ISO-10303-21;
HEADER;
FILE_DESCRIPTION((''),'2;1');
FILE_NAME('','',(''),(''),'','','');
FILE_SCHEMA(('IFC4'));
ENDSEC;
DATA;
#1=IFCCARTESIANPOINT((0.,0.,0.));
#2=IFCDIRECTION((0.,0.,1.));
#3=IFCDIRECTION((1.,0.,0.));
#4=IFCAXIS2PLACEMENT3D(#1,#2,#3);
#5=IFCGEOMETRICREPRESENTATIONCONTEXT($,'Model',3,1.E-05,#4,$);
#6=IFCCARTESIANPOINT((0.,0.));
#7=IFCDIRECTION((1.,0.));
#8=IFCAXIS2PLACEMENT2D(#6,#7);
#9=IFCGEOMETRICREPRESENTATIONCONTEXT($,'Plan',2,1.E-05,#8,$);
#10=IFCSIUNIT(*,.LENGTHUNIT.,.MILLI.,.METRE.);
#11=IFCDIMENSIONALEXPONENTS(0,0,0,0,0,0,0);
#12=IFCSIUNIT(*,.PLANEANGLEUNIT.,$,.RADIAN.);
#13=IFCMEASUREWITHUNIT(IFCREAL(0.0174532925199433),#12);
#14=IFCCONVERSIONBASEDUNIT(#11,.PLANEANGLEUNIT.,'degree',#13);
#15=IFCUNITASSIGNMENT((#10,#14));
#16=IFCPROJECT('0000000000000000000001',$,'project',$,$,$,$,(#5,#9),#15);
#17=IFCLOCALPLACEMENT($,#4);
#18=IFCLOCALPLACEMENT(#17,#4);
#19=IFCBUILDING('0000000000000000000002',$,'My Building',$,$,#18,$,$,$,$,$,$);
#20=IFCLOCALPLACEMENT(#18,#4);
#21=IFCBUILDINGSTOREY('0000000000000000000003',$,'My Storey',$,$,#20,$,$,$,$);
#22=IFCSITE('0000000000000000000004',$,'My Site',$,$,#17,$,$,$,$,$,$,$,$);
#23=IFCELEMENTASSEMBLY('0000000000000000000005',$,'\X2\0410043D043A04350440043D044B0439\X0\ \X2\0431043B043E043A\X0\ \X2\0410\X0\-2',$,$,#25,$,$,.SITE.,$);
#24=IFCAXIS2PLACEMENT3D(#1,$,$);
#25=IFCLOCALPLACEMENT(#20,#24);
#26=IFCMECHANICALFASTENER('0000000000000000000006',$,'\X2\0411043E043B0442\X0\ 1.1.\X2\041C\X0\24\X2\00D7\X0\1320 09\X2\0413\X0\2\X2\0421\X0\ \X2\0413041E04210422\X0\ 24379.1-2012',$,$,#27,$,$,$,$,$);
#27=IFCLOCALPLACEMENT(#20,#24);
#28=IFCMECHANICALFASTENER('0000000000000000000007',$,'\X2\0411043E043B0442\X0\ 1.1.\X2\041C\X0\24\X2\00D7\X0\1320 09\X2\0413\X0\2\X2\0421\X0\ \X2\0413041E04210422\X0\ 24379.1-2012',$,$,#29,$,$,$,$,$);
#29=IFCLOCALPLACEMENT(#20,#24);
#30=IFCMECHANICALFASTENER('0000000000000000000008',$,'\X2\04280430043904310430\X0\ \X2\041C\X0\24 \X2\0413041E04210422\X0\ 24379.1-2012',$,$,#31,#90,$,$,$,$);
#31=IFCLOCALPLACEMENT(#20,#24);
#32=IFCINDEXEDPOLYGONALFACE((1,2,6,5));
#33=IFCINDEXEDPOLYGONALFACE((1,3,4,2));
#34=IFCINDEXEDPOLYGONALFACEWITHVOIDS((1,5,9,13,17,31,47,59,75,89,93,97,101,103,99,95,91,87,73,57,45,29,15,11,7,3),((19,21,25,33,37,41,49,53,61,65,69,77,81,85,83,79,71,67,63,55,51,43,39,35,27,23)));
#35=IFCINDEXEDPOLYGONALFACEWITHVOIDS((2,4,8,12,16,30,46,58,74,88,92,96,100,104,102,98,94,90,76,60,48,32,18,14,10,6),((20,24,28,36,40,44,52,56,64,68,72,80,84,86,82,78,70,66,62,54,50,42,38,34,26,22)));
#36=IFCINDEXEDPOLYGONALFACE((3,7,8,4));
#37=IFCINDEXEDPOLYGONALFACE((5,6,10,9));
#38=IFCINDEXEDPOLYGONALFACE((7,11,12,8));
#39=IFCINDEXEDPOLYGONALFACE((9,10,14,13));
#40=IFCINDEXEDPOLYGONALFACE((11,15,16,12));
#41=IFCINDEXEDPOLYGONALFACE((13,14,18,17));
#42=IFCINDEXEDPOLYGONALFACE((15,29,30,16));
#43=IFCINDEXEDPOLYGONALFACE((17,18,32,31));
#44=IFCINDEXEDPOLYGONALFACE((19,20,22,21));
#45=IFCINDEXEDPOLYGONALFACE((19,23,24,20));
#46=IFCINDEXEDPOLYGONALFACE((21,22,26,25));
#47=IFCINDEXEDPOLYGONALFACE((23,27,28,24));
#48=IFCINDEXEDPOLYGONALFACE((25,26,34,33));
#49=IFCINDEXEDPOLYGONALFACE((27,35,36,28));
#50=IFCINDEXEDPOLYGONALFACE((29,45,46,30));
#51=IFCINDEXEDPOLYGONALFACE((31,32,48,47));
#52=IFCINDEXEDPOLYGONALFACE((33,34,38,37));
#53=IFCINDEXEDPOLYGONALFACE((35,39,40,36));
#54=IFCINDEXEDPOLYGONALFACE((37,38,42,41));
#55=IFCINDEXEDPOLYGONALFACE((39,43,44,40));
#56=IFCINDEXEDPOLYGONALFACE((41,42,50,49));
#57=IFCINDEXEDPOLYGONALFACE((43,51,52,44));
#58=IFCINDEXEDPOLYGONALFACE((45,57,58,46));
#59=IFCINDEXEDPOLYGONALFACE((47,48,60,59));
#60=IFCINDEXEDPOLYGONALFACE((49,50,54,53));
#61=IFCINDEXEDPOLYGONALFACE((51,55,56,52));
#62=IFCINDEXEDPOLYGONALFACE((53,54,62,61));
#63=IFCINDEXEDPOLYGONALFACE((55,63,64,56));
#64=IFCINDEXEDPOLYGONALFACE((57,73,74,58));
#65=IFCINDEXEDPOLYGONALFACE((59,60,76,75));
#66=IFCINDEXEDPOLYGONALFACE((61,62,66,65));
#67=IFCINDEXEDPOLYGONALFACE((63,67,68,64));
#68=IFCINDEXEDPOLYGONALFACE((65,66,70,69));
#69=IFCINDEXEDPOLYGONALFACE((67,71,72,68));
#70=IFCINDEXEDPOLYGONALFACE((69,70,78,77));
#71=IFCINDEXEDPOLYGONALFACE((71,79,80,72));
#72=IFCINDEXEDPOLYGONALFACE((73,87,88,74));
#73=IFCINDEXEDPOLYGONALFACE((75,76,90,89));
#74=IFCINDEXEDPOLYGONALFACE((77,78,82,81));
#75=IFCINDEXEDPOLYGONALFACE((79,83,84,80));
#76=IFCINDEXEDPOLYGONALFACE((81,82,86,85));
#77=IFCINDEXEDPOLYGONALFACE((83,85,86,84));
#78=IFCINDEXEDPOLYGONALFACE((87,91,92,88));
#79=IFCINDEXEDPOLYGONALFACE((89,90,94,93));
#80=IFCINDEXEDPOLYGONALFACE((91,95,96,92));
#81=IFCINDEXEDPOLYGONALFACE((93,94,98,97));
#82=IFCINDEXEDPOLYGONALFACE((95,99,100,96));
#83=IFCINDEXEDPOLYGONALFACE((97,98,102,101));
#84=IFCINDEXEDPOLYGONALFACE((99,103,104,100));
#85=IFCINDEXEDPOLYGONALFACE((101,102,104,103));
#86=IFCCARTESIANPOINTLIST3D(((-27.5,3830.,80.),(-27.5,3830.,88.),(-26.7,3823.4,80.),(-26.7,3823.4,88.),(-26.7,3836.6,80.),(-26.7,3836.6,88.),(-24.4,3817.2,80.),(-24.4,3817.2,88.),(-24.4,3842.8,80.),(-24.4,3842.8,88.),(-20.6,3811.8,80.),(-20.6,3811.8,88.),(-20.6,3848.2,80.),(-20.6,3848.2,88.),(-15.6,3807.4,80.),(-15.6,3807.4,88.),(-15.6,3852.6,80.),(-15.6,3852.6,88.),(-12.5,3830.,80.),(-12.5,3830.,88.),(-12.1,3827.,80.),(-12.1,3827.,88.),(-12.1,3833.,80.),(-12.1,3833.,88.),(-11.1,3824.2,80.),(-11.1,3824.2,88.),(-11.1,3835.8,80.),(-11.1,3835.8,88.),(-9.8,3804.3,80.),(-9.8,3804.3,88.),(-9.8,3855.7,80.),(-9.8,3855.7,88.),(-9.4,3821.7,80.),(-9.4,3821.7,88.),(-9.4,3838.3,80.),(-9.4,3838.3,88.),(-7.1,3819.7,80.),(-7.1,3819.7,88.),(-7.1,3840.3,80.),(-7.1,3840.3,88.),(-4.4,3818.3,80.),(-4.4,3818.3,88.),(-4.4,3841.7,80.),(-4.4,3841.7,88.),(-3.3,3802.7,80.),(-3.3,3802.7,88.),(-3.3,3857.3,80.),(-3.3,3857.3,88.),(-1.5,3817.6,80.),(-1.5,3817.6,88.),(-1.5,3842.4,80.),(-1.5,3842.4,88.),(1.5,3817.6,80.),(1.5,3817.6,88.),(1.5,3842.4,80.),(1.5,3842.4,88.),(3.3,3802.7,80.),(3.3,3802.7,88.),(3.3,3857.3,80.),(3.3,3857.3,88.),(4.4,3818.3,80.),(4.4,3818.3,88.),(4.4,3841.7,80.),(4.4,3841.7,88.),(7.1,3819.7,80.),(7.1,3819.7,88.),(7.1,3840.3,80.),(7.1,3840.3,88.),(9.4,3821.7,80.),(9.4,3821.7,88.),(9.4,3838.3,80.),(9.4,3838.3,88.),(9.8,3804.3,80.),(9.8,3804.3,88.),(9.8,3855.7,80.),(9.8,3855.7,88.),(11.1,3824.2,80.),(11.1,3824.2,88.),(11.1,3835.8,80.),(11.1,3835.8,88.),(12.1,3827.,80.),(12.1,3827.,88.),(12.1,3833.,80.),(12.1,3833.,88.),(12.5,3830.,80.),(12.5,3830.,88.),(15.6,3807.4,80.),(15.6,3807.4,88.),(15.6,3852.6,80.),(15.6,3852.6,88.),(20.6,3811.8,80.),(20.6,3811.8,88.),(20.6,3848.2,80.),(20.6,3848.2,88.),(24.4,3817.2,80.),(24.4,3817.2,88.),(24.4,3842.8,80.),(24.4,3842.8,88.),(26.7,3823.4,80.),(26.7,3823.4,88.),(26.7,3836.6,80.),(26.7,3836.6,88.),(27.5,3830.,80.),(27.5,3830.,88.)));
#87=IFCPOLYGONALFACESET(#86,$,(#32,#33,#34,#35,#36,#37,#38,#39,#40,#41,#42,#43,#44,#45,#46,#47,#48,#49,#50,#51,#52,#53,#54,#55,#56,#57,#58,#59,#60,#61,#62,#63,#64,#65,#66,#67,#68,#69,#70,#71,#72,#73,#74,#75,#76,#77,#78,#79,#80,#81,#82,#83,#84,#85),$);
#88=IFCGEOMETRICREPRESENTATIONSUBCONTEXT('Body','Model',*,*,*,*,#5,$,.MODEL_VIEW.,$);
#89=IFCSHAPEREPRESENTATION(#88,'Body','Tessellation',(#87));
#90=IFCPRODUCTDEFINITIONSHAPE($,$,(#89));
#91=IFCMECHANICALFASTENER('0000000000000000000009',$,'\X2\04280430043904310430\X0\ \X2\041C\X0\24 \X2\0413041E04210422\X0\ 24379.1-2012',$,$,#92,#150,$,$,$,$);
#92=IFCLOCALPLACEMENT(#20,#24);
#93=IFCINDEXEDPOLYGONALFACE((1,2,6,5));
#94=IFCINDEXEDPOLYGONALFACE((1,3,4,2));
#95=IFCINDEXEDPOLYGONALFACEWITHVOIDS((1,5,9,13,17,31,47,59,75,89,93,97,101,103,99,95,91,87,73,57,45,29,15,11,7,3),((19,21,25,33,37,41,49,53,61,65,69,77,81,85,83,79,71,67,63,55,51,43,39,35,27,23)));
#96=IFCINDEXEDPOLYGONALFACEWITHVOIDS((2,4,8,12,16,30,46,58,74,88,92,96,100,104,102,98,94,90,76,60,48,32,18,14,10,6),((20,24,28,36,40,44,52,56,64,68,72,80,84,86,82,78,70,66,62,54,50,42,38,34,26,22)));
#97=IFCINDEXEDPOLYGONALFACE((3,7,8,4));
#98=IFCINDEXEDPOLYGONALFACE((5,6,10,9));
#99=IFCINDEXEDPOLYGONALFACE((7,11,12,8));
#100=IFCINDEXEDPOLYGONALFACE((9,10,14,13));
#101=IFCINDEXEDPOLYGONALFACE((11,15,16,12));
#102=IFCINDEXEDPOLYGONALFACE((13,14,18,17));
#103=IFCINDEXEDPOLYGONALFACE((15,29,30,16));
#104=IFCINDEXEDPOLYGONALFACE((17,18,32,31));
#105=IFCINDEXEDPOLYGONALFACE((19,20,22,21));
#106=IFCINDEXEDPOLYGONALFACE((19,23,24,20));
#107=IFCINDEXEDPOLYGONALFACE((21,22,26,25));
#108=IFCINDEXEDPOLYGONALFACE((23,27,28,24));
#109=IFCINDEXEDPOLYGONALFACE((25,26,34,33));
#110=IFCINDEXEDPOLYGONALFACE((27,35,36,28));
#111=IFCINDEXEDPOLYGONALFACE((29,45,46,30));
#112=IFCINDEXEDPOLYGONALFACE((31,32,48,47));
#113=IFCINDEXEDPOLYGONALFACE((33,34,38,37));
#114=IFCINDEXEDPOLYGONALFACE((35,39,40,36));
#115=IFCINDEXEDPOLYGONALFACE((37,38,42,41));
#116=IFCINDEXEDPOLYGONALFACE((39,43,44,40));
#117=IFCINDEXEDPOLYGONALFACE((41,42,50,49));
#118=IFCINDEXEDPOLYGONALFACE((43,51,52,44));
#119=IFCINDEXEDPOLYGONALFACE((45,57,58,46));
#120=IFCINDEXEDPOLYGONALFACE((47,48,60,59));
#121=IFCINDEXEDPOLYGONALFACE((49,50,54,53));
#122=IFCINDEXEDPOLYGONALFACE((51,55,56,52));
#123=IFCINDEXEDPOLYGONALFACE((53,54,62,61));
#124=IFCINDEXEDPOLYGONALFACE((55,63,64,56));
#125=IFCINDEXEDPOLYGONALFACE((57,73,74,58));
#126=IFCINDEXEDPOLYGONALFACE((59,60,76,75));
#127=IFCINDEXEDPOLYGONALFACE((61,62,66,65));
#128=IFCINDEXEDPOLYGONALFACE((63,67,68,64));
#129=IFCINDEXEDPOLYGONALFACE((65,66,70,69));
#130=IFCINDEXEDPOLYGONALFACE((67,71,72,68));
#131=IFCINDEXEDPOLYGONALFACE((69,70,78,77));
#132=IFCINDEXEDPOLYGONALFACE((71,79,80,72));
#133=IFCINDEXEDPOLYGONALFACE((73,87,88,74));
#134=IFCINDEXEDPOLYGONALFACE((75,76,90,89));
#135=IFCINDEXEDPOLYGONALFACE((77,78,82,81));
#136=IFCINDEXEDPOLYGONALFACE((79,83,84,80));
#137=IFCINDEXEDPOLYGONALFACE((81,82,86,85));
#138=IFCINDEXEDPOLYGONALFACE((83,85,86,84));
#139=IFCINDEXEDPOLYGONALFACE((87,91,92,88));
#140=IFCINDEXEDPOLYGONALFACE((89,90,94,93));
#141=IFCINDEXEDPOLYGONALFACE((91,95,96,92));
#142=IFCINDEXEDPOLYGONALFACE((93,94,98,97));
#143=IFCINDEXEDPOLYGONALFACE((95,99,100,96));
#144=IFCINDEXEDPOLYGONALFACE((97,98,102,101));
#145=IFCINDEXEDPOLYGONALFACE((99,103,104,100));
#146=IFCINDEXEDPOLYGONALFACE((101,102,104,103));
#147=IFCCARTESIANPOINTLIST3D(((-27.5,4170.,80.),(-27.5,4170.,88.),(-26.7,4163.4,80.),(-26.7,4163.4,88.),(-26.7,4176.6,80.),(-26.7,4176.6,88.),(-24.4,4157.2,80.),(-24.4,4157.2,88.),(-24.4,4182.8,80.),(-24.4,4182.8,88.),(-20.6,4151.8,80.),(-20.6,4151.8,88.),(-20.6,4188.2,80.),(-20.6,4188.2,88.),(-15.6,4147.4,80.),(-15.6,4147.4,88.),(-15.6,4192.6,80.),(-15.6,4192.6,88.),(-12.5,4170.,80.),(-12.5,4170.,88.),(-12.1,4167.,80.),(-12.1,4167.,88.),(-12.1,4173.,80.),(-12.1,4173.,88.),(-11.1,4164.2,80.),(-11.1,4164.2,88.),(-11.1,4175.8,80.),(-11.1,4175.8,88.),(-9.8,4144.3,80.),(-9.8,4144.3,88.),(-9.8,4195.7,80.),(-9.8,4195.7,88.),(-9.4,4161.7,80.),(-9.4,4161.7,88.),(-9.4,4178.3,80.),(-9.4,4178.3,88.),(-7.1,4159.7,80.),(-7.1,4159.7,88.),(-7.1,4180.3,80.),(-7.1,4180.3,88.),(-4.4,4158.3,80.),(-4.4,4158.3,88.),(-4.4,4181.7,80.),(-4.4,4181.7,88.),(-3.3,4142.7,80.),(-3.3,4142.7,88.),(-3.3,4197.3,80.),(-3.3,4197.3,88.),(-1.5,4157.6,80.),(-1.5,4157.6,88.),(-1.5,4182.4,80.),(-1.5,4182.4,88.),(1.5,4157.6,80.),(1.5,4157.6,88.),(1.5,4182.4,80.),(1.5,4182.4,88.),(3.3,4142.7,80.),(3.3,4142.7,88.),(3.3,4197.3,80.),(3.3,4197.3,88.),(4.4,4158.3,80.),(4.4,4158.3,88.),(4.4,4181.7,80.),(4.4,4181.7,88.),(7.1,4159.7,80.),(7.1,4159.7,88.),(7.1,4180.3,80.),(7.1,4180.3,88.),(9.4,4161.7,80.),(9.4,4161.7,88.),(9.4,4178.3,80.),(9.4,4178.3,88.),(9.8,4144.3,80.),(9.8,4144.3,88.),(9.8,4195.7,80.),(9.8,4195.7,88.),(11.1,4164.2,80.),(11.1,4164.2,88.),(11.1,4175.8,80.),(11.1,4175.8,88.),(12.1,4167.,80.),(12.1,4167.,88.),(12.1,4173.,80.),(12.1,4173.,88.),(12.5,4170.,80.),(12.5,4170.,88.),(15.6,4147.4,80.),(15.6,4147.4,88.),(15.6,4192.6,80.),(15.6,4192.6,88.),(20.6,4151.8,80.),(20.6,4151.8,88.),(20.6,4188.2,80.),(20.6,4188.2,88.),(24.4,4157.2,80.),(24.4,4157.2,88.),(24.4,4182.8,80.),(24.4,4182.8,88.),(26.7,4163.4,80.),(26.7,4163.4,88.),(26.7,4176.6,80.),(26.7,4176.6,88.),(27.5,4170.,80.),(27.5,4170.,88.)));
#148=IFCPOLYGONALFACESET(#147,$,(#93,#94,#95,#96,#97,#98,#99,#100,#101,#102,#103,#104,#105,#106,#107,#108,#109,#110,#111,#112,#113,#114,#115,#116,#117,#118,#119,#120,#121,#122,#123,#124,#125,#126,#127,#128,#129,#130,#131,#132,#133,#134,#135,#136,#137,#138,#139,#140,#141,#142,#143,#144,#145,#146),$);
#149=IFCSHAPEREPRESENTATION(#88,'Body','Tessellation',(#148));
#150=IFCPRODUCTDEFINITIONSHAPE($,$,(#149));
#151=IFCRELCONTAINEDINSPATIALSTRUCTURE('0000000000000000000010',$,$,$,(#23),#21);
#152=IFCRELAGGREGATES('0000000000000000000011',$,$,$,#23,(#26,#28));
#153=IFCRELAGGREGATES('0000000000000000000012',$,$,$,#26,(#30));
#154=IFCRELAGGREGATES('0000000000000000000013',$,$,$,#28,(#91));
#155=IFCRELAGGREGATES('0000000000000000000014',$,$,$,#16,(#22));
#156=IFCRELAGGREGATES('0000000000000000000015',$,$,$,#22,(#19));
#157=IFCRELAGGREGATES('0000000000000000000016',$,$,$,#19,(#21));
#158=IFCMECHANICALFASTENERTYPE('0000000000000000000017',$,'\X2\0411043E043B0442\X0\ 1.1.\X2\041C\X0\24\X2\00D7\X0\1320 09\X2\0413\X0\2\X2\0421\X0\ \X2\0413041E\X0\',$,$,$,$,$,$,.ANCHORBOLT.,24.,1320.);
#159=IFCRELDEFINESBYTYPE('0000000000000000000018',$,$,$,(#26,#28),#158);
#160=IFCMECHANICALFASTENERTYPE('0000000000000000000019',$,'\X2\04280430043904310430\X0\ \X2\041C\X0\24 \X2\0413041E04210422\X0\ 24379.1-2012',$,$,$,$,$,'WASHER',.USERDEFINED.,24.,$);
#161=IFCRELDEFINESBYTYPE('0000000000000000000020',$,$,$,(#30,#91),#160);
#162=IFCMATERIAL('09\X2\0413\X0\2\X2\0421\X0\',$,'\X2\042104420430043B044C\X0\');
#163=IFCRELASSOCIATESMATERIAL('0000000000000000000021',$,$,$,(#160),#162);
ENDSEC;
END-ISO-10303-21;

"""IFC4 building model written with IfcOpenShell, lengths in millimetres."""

from ifc_helpers import new_model, entity, si_unit, converted_unit, frame, origin_with_axes, origin_2d_with_axis, place, context, subcontext, project, spatial, polyline, outline, extrude, source, transform, mapped, material, type_object, type_shapes, element, aggregate, save


model = new_model("IFC4")

# Units and contexts
model_context = context("Model", 3, precision=1e-05, world=origin_with_axes())
plan_context = context("Plan", 2, precision=1e-05, world=origin_2d_with_axis())
body_context = subcontext(model_context, "Body", "Model", "MODEL_VIEW")
ifc_project = project(units=[si_unit("LENGTHUNIT", "METRE", prefix="MILLI"), converted_unit("PLANEANGLEUNIT", "degree", entity("IfcReal", 0.0174532925199433), si_unit("PLANEANGLEUNIT", "RADIAN"), dimensions=[0, 0, 0, 0, 0, 0, 0])], contexts=[model_context, plan_context])

# Site, building, storey
site_placement = place(None, origin_with_axes())
site = spatial("IfcSite", under=ifc_project, at=site_placement, Name="My Site")
building_placement = place(site_placement, origin_with_axes())
building = spatial("IfcBuilding", under=site, at=building_placement, Name="My Building")
storey_placement = place(building_placement, origin_with_axes())
storey = spatial("IfcBuildingStorey", under=building, at=storey_placement, Name="My Storey")

# Element assembly, mechanical fasteners
ifc_material_1 = material(Name="09Г2С", Category="Сталь")
mechanical_fastener_type_1 = type_object("IfcMechanicalFastenerType", Name="Болт 1.1.М24×1320 09Г2С ГО", NominalDiameter=24.0, NominalLength=1320.0, PredefinedType="ANCHORBOLT")
assembly_1_placement = place(storey_placement, frame((0.0, 4000.0, 0.0), z_axis=(0.0, 0.0, 1.0), x_axis=(1.0, 0.0, 0.0)))
assembly_1 = element("IfcElementAssembly", 1, at=assembly_1_placement, inside=storey, Name="Анкерный блок А-2", AssemblyPlace="SITE")
mechanical_fastener_1_placement = place(assembly_1_placement, frame((0.0, -170.0, 0.0), z_axis=(0.0, 0.0, 1.0), x_axis=(1.0, 0.0, 0.0)))
mechanical_fastener_1 = element("IfcMechanicalFastener", 2, at=mechanical_fastener_1_placement, type_object=mechanical_fastener_type_1, Name="Болт 1.1.М24×1320 09Г2С ГОСТ 24379.1-2012")
mechanical_fastener_2_placement = place(assembly_1_placement, frame((0.0, 170.0, 0.0), z_axis=(0.0, 0.0, 1.0), x_axis=(-1.0, 0.0, 0.0)))
mechanical_fastener_2 = element("IfcMechanicalFastener", 3, at=mechanical_fastener_2_placement, type_object=mechanical_fastener_type_1, Name="Болт 1.1.М24×1320 09Г2С ГОСТ 24379.1-2012")
aggregate(assembly_1, [mechanical_fastener_1, mechanical_fastener_2])

# Mechanical fasteners
mechanical_fastener_type_2 = type_object("IfcMechanicalFastenerType", Name="Шайба М24 ГОСТ 24379.1-2012", ElementType="WASHER", NominalDiameter=24.0, PredefinedType="USERDEFINED", material=ifc_material_1)
shared_shape_1 = source(origin_with_axes(), body_context, "Body", "SweptSolid", [
    extrude(outline(polyline([(27.5, 0.0), (26.7, 6.6), (24.4, 12.8), (20.6, 18.2), (15.6, 22.6), (9.8, 25.7), (3.3, 27.3), (-3.3, 27.3), (-9.8, 25.7), (-15.6, 22.6), (-20.6, 18.2), (-24.4, 12.8), (-26.7, 6.6), (-27.5, 0.0), (-26.7, -6.6), (-24.4, -12.8), (-20.6, -18.2), (-15.6, -22.6), (-9.8, -25.7), (-3.3, -27.3), (3.3, -27.3), (9.8, -25.7), (15.6, -22.6), (20.6, -18.2), (24.4, -12.8), (26.7, -6.6), (27.5, 0.0)]), holes=[polyline([(-4.4, -11.7), (-7.1, -10.3), (-9.4, -8.3), (-11.1, -5.8), (-12.1, -3.0), (-12.5, 0.0), (-12.1, 3.0), (-11.1, 5.8), (-9.4, 8.3), (-7.1, 10.3), (-4.4, 11.7), (-1.5, 12.4), (1.5, 12.4), (4.4, 11.7), (7.1, 10.3), (9.4, 8.3), (11.1, 5.8), (12.1, 3.0), (12.5, 0.0), (12.1, -3.0), (11.1, -5.8), (9.4, -8.3), (7.1, -10.3), (4.4, -11.7), (1.5, -12.4), (-1.5, -12.4), (-4.4, -11.7)])]), frame((0.0, 0.0, 0.0), z_axis=(0.0, 0.0, 1.0), x_axis=(0.120537, -0.992709, 0.0)), (0.0, 0.0, 1.0), 8.0),
])
type_shapes(mechanical_fastener_type_2, [shared_shape_1])
mechanical_fastener_3_placement = place(mechanical_fastener_1_placement, frame((0.0, 0.0, 80.0), z_axis=(0.0, 0.0, 1.0), x_axis=(1.0, 0.0, 0.0)))
mechanical_fastener_3 = element("IfcMechanicalFastener", 4, at=mechanical_fastener_3_placement, type_object=mechanical_fastener_type_2, Name="Шайба М24 ГОСТ 24379.1-2012", context=body_context, shape_type="MappedRepresentation", body=[
    mapped(shared_shape_1, transform((0.0, 0.0, 0.0), x_axis=(1.0, 0.0, 0.0), y_axis=(0.0, 1.0, 0.0), z_axis=(0.0, 0.0, 1.0), scale=1.0)),
])
aggregate(mechanical_fastener_1, [mechanical_fastener_3])
mechanical_fastener_4_placement = place(mechanical_fastener_2_placement, frame((0.0, 0.0, 80.0), z_axis=(0.0, 0.0, 1.0), x_axis=(1.0, 0.0, 0.0)))
mechanical_fastener_4 = element("IfcMechanicalFastener", 5, at=mechanical_fastener_4_placement, type_object=mechanical_fastener_type_2, Name="Шайба М24 ГОСТ 24379.1-2012", context=body_context, shape_type="MappedRepresentation", body=[
    mapped(shared_shape_1, transform((0.0, 0.0, 0.0), x_axis=(1.0, 0.0, 0.0), y_axis=(0.0, 1.0, 0.0), z_axis=(0.0, 0.0, 1.0), scale=1.0)),
])
aggregate(mechanical_fastener_2, [mechanical_fastener_4])

save(model, "model.ifc")
